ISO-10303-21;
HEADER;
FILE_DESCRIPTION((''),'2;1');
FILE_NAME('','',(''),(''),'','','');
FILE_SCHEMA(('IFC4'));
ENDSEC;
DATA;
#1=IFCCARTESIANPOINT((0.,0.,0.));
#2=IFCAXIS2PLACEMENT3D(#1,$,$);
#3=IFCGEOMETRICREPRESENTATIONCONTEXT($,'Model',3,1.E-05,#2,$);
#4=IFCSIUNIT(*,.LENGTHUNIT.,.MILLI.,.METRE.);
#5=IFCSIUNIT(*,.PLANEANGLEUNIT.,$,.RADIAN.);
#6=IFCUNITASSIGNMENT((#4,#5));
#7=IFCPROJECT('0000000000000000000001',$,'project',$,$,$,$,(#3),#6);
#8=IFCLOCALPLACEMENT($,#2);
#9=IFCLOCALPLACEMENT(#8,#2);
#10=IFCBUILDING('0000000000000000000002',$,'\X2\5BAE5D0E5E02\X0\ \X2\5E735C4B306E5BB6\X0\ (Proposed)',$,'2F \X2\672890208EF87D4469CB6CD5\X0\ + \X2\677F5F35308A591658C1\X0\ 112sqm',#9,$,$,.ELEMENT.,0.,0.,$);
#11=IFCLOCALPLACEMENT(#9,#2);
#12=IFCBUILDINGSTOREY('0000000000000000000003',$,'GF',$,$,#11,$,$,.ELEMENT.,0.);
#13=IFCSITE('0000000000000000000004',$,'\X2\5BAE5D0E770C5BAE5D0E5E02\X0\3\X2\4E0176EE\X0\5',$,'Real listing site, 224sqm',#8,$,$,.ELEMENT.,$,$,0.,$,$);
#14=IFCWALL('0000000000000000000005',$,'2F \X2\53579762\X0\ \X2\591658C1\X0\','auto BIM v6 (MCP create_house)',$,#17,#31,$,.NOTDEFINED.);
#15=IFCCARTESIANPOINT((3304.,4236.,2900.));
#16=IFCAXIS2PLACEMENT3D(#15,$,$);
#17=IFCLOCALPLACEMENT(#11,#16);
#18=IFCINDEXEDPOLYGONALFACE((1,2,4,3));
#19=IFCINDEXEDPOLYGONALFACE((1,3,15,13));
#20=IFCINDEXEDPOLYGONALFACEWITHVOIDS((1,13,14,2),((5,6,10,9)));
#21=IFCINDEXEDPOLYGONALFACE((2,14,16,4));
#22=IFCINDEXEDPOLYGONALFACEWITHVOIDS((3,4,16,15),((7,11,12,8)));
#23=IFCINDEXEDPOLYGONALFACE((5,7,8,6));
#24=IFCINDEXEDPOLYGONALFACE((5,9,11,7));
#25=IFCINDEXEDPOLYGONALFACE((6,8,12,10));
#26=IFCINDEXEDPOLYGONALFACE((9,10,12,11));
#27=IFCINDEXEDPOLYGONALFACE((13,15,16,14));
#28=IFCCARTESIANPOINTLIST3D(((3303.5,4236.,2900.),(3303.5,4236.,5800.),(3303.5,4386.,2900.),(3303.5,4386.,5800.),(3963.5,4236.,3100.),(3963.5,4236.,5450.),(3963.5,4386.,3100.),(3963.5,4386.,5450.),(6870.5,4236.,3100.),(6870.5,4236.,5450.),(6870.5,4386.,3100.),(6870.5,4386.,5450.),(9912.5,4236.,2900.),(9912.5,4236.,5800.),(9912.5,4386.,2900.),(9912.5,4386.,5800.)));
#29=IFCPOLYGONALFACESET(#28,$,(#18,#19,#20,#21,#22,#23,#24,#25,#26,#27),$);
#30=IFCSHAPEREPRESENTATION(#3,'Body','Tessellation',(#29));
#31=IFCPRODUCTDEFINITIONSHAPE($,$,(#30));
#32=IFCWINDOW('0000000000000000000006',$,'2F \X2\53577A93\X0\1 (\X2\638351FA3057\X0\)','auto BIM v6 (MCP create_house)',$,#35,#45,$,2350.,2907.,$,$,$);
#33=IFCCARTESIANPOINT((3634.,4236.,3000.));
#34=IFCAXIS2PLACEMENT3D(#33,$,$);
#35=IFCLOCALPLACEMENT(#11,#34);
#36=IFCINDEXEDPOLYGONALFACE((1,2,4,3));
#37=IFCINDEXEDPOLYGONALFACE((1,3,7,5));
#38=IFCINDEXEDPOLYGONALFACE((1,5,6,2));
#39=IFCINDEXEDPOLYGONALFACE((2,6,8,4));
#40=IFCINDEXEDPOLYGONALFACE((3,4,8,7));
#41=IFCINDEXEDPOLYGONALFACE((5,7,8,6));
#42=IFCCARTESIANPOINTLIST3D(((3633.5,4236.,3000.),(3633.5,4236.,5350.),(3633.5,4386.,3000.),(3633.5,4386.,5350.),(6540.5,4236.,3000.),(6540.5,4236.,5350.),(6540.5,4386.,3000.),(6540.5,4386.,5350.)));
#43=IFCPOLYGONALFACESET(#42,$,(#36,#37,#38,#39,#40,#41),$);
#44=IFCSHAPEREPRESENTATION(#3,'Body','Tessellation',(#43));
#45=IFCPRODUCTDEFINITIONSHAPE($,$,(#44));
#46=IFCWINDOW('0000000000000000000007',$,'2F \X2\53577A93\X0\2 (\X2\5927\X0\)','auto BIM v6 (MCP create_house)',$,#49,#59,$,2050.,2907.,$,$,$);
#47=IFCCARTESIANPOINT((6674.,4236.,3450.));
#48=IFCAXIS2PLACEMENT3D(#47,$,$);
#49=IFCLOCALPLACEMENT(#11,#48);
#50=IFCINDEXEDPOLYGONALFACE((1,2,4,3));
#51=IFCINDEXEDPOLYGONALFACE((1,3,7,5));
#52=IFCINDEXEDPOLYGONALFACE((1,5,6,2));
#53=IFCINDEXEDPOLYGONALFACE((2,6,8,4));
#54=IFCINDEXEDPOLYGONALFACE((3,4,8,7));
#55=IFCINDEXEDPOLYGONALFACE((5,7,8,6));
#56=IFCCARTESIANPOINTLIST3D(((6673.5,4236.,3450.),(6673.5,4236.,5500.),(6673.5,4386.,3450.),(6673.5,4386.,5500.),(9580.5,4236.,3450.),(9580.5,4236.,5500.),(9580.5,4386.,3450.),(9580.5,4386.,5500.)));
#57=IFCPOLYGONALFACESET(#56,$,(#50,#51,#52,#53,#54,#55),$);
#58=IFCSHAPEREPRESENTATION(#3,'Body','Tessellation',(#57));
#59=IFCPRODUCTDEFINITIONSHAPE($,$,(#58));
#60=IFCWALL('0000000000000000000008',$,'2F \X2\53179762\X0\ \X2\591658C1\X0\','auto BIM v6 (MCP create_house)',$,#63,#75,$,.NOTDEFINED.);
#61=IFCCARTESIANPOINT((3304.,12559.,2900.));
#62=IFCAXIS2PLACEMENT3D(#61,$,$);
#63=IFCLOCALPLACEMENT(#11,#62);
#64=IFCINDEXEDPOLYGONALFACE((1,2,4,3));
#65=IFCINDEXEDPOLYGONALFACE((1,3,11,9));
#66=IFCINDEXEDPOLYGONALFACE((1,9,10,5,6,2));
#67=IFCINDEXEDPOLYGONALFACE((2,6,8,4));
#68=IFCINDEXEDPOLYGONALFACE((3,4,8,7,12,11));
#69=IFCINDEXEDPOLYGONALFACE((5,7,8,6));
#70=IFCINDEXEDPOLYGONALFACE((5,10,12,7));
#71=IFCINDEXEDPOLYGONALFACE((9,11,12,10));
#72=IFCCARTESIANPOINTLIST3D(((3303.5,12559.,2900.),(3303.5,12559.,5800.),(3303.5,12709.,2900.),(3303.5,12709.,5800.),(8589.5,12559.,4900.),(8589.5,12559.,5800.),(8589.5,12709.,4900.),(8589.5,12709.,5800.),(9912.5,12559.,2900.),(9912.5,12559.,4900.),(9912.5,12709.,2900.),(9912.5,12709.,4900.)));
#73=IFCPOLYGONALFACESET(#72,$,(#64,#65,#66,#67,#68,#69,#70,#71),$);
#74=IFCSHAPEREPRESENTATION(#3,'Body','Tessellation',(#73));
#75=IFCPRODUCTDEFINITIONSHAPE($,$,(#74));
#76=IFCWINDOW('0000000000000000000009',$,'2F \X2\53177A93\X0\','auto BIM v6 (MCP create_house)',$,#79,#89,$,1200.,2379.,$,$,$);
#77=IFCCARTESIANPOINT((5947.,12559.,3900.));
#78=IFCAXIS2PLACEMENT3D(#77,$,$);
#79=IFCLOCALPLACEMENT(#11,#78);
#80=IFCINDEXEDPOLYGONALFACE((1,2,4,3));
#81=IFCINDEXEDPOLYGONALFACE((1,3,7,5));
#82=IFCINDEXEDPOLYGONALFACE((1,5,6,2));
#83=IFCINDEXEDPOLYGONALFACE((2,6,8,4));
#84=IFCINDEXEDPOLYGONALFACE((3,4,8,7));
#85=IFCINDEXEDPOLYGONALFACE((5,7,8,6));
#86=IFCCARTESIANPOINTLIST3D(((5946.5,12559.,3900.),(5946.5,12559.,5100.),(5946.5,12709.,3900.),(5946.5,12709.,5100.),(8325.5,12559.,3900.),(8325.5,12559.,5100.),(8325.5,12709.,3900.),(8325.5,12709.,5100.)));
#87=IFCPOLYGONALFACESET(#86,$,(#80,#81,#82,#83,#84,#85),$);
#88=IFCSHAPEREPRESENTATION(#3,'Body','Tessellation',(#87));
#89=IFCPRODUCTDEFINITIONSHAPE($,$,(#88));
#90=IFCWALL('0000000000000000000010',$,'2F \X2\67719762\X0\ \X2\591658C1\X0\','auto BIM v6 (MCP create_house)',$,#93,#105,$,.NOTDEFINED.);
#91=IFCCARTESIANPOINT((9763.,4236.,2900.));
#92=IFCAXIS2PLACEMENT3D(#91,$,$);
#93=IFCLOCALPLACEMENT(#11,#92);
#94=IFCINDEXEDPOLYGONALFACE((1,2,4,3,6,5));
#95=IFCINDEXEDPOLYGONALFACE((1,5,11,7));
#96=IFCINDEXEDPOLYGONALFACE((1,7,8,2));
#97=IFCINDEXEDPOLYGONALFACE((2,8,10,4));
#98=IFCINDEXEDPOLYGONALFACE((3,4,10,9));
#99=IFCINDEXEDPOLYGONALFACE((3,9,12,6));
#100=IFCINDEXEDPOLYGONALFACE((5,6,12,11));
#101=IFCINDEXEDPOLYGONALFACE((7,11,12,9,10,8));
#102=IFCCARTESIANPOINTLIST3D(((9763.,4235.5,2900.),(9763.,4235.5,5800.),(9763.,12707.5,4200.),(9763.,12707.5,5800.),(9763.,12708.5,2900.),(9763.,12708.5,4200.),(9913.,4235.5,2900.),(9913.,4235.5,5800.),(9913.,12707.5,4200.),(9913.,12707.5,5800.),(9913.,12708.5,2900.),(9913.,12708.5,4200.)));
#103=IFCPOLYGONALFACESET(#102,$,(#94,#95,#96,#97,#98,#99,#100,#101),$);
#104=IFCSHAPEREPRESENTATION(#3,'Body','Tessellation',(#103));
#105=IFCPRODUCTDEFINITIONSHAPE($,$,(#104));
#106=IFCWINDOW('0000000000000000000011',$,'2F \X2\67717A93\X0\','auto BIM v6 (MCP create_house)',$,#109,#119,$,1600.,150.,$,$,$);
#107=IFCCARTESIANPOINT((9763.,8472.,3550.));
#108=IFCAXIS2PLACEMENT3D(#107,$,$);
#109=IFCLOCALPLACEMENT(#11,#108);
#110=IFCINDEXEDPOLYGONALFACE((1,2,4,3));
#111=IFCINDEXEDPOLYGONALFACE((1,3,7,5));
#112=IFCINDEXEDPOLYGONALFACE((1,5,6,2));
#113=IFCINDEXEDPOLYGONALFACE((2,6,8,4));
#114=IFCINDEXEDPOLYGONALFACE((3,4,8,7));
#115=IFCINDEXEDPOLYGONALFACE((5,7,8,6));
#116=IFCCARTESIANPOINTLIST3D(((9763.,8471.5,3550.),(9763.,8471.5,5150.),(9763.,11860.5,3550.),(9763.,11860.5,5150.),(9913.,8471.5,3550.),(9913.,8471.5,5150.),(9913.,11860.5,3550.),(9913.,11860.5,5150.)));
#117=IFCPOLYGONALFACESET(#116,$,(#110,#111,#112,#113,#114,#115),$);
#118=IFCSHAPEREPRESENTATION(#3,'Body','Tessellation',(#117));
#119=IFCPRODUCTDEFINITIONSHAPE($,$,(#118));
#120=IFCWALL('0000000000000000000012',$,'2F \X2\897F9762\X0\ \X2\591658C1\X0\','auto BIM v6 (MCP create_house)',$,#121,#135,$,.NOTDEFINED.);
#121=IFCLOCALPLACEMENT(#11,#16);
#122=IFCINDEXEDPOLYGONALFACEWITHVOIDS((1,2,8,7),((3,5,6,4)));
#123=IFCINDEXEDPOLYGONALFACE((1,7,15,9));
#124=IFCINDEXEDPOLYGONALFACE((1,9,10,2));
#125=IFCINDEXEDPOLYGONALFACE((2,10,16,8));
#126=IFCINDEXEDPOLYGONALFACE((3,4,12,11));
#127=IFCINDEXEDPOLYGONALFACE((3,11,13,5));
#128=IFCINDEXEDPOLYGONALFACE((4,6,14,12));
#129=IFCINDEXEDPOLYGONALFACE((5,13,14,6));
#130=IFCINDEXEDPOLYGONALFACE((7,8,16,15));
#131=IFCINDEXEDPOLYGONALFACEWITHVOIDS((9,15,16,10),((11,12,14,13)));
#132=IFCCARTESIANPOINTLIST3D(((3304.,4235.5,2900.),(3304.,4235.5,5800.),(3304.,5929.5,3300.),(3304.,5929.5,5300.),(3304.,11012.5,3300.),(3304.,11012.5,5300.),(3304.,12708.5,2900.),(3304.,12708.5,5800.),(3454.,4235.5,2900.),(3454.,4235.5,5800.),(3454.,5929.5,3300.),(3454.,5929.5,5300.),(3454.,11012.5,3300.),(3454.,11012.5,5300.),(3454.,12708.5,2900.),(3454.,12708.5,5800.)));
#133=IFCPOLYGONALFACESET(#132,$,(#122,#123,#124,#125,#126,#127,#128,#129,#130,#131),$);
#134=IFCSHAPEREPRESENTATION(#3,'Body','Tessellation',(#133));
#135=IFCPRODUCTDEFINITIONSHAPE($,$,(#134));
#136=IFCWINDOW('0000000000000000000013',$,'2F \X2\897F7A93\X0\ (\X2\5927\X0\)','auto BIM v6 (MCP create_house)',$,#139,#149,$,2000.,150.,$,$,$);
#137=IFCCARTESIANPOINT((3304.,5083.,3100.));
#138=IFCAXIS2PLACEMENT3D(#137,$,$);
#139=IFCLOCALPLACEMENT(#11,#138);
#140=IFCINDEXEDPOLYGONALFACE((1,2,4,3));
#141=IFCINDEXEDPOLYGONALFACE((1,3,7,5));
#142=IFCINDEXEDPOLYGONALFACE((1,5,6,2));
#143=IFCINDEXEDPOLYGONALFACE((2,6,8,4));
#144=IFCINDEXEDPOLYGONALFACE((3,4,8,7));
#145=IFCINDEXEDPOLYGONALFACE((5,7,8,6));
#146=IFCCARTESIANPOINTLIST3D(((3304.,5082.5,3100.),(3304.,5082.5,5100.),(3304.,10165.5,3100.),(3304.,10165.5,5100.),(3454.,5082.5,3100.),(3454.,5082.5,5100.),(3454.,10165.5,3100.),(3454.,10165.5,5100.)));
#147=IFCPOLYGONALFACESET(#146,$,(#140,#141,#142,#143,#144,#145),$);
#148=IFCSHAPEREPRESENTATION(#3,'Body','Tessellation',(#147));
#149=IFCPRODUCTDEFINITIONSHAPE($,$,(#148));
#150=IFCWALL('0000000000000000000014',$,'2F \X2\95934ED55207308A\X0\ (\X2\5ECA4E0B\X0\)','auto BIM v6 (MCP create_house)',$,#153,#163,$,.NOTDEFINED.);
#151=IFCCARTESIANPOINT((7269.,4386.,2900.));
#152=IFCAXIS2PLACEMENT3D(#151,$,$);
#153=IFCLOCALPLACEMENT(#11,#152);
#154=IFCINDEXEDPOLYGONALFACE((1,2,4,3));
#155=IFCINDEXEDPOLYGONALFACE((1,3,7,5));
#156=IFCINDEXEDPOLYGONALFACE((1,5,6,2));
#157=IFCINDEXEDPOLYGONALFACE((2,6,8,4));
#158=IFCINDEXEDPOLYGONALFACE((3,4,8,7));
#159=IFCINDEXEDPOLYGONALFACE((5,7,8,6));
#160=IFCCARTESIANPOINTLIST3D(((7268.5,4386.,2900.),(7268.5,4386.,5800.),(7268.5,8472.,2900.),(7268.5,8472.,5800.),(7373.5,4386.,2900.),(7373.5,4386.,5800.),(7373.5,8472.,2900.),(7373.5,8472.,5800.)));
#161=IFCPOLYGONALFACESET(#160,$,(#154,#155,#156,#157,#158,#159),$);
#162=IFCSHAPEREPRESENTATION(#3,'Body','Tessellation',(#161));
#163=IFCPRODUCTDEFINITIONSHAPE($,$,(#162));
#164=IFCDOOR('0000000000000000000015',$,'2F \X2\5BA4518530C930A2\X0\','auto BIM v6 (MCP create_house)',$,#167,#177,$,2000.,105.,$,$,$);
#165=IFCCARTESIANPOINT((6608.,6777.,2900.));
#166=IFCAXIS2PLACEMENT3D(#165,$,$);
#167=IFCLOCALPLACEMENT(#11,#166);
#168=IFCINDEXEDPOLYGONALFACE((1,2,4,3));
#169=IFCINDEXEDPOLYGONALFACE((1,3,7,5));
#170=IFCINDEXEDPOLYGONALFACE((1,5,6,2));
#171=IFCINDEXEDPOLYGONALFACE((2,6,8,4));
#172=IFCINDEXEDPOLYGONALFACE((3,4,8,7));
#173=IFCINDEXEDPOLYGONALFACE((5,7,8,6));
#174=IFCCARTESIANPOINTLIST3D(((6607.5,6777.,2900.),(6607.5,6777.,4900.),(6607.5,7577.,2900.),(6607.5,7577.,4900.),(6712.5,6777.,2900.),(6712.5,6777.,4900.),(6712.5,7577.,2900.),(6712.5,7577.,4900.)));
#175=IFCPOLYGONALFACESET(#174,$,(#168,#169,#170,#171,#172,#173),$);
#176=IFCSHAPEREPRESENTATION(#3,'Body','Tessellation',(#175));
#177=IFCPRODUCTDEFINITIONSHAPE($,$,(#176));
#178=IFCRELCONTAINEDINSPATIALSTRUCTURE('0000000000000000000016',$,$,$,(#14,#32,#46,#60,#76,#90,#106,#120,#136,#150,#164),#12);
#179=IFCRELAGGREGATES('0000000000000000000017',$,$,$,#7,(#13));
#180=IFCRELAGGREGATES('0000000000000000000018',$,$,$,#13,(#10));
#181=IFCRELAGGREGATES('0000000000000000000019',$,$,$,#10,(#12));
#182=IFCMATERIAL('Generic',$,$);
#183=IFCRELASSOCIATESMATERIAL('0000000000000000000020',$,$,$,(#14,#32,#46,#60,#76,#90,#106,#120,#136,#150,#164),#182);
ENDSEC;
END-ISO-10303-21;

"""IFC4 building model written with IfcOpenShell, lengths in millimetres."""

from ifc_helpers import new_model, si_unit, frame, frame_2d, origin, place, context, project, spatial, rectangle, extrude, material, element, fill, save


model = new_model("IFC4")

# Units and contexts
model_context = context("Model", 3, precision=1e-05, world=origin())
ifc_project = project(units=[si_unit("LENGTHUNIT", "METRE", prefix="MILLI"), si_unit("PLANEANGLEUNIT", "RADIAN")], contexts=[model_context])

# Site, building, storey
site_placement = place(None, origin())
site = spatial("IfcSite", under=ifc_project, at=site_placement, Name="宮崎県宮崎市3丁目5", ObjectType="Real listing site, 224sqm", CompositionType="ELEMENT", RefElevation=0.0)
building_placement = place(site_placement, origin())
building = spatial("IfcBuilding", under=site, at=building_placement, Name="宮崎市 平屋の家 (Proposed)", ObjectType="2F 木造軸組構法 + 板張り外壁 112sqm", CompositionType="ELEMENT", ElevationOfRefHeight=0.0, ElevationOfTerrain=0.0)
storey_placement = place(building_placement, origin())
storey = spatial("IfcBuildingStorey", under=building, at=storey_placement, Name="GF", CompositionType="ELEMENT", Elevation=0.0)

# Shared definitions
ifc_material = material(Name="Generic")

# Wall, openings, windows
wall_1_placement = place(storey_placement, frame((3304.0, 4236.0, 2900.0)))
wall_1 = element("IfcWall", 1, at=wall_1_placement, inside=storey, material=ifc_material, Name="2F 南面 外壁", Description="auto BIM v6 (MCP create_house)", PredefinedType="NOTDEFINED", context=model_context, shape_type="SweptSolid", body=[
    extrude(rectangle(XDim=6609.0, YDim=150.0, at=frame_2d((3304.0, 75.0))), frame((3304.0, 4236.0, 2900.0)), (0.0, 0.0, 1.0), 2900.0),
])
opening_1_placement = place(storey_placement, frame((3634.0, 4236.0, 3000.0)))
opening_1 = element("IfcOpeningElement", 2, at=opening_1_placement, cuts=wall_1, PredefinedType="NOTDEFINED", context=model_context, shape_type="SweptSolid", body=[
    extrude(rectangle(XDim=2907.0, YDim=150.0, at=frame_2d((1453.0, 75.0))), frame((3634.0, 4236.0, 3000.0)), (0.0, 0.0, 1.0), 2350.0),
])
opening_2_placement = place(storey_placement, frame((6674.0, 4236.0, 3450.0)))
opening_2 = element("IfcOpeningElement", 3, at=opening_2_placement, cuts=wall_1, PredefinedType="NOTDEFINED", context=model_context, shape_type="SweptSolid", body=[
    extrude(rectangle(XDim=2907.0, YDim=150.0, at=frame_2d((1453.0, 75.0))), frame((6674.0, 4236.0, 3450.0)), (0.0, 0.0, 1.0), 2050.0),
])
window_1_placement = place(storey_placement, frame((3634.0, 4236.0, 3000.0)))
window_1 = element("IfcWindow", 4, at=window_1_placement, inside=storey, material=ifc_material, Name="2F 南窓1 (掃出し)", Description="auto BIM v6 (MCP create_house)", OverallHeight=2350.0, OverallWidth=2907.0, context=model_context, shape_type="SweptSolid", body=[
    extrude(rectangle(XDim=2907.0, YDim=150.0, at=frame_2d((1453.0, 75.0))), frame((3634.0, 4236.0, 3000.0)), (0.0, 0.0, 1.0), 2350.0),
])
fill(opening_1, window_1)
window_2_placement = place(storey_placement, frame((6674.0, 4236.0, 3450.0)))
window_2 = element("IfcWindow", 5, at=window_2_placement, inside=storey, material=ifc_material, Name="2F 南窓2 (大)", Description="auto BIM v6 (MCP create_house)", OverallHeight=2050.0, OverallWidth=2907.0, context=model_context, shape_type="SweptSolid", body=[
    extrude(rectangle(XDim=2907.0, YDim=150.0, at=frame_2d((1453.0, 75.0))), frame((6674.0, 4236.0, 3450.0)), (0.0, 0.0, 1.0), 2050.0),
])
fill(opening_2, window_2)

# Walls, openings, windows
wall_2_placement = place(storey_placement, frame((3304.0, 12559.0, 2900.0)))
wall_2 = element("IfcWall", 6, at=wall_2_placement, inside=storey, material=ifc_material, Name="2F 北面 外壁", Description="auto BIM v6 (MCP create_house)", PredefinedType="NOTDEFINED", context=model_context, shape_type="SweptSolid", body=[
    extrude(rectangle(XDim=6609.0, YDim=150.0, at=frame_2d((3304.0, 75.0))), frame((3304.0, 12559.0, 2900.0)), (0.0, 0.0, 1.0), 2900.0),
])
opening_3_placement = place(storey_placement, frame((5947.0, 12559.0, 3900.0)))
opening_3 = element("IfcOpeningElement", 7, at=opening_3_placement, cuts=wall_2, PredefinedType="NOTDEFINED", context=model_context, shape_type="SweptSolid", body=[
    extrude(rectangle(XDim=2379.0, YDim=150.0, at=frame_2d((1189.0, 75.0))), frame((5947.0, 12559.0, 3900.0)), (0.0, 0.0, 1.0), 1200.0),
])
window_3_placement = place(storey_placement, frame((5947.0, 12559.0, 3900.0)))
window_3 = element("IfcWindow", 8, at=window_3_placement, inside=storey, material=ifc_material, Name="2F 北窓", Description="auto BIM v6 (MCP create_house)", OverallHeight=1200.0, OverallWidth=2379.0, context=model_context, shape_type="SweptSolid", body=[
    extrude(rectangle(XDim=2379.0, YDim=150.0, at=frame_2d((1189.0, 75.0))), frame((5947.0, 12559.0, 3900.0)), (0.0, 0.0, 1.0), 1200.0),
])
fill(opening_3, window_3)
wall_3_placement = place(storey_placement, frame((9763.0, 4236.0, 2900.0)))
wall_3 = element("IfcWall", 9, at=wall_3_placement, inside=storey, material=ifc_material, Name="2F 東面 外壁", Description="auto BIM v6 (MCP create_house)", PredefinedType="NOTDEFINED", context=model_context, shape_type="SweptSolid", body=[
    extrude(rectangle(XDim=150.0, YDim=8473.0, at=frame_2d((75.0, 4236.0))), frame((9763.0, 4236.0, 2900.0)), (0.0, 0.0, 1.0), 2900.0),
])
opening_4_placement = place(storey_placement, frame((9763.0, 8472.0, 3550.0)))
opening_4 = element("IfcOpeningElement", 10, at=opening_4_placement, cuts=wall_3, PredefinedType="NOTDEFINED", context=model_context, shape_type="SweptSolid", body=[
    extrude(rectangle(XDim=150.0, YDim=3389.0, at=frame_2d((75.0, 1694.0))), frame((9763.0, 8472.0, 3550.0)), (0.0, 0.0, 1.0), 1600.0),
])
window_4_placement = place(storey_placement, frame((9763.0, 8472.0, 3550.0)))
window_4 = element("IfcWindow", 11, at=window_4_placement, inside=storey, material=ifc_material, Name="2F 東窓", Description="auto BIM v6 (MCP create_house)", OverallHeight=1600.0, OverallWidth=150.0, context=model_context, shape_type="SweptSolid", body=[
    extrude(rectangle(XDim=150.0, YDim=3389.0, at=frame_2d((75.0, 1694.0))), frame((9763.0, 8472.0, 3550.0)), (0.0, 0.0, 1.0), 1600.0),
])
fill(opening_4, window_4)
wall_4_placement = place(storey_placement, frame((3304.0, 4236.0, 2900.0)))
wall_4 = element("IfcWall", 12, at=wall_4_placement, inside=storey, material=ifc_material, Name="2F 西面 外壁", Description="auto BIM v6 (MCP create_house)", PredefinedType="NOTDEFINED", context=model_context, shape_type="SweptSolid", body=[
    extrude(rectangle(XDim=150.0, YDim=8473.0, at=frame_2d((75.0, 4236.0))), frame((3304.0, 4236.0, 2900.0)), (0.0, 0.0, 1.0), 2900.0),
])
opening_5_placement = place(storey_placement, frame((3304.0, 5083.0, 3100.0)))
opening_5 = element("IfcOpeningElement", 13, at=opening_5_placement, cuts=wall_4, PredefinedType="NOTDEFINED", context=model_context, shape_type="SweptSolid", body=[
    extrude(rectangle(XDim=150.0, YDim=5083.0, at=frame_2d((75.0, 2541.0))), frame((3304.0, 5083.0, 3100.0)), (0.0, 0.0, 1.0), 2000.0),
])
window_5_placement = place(storey_placement, frame((3304.0, 5083.0, 3100.0)))
window_5 = element("IfcWindow", 14, at=window_5_placement, inside=storey, material=ifc_material, Name="2F 西窓 (大)", Description="auto BIM v6 (MCP create_house)", OverallHeight=2000.0, OverallWidth=150.0, context=model_context, shape_type="SweptSolid", body=[
    extrude(rectangle(XDim=150.0, YDim=5083.0, at=frame_2d((75.0, 2541.0))), frame((3304.0, 5083.0, 3100.0)), (0.0, 0.0, 1.0), 2000.0),
])
fill(opening_5, window_5)

# Wall
wall_5_placement = place(storey_placement, frame((7269.0, 4386.0, 2900.0)))
element("IfcWall", 15, at=wall_5_placement, inside=storey, material=ifc_material, Name="2F 間仕切り (廊下)", Description="auto BIM v6 (MCP create_house)", PredefinedType="NOTDEFINED", context=model_context, shape_type="SweptSolid", body=[
    extrude(rectangle(XDim=105.0, YDim=4086.0, at=frame_2d((52.0, 2043.0))), frame((7269.0, 4386.0, 2900.0)), (0.0, 0.0, 1.0), 2900.0),
])

# Door
door_1_placement = place(storey_placement, frame((6608.0, 6777.0, 2900.0)))
element("IfcDoor", 16, at=door_1_placement, inside=storey, material=ifc_material, Name="2F 室内ドア", Description="auto BIM v6 (MCP create_house)", OverallHeight=2000.0, OverallWidth=105.0, context=model_context, shape_type="SweptSolid", body=[
    extrude(rectangle(XDim=105.0, YDim=800.0, at=frame_2d((52.0, 400.0))), frame((6608.0, 6777.0, 2900.0)), (0.0, 0.0, 1.0), 2000.0),
])

save(model, "model.ifc")
